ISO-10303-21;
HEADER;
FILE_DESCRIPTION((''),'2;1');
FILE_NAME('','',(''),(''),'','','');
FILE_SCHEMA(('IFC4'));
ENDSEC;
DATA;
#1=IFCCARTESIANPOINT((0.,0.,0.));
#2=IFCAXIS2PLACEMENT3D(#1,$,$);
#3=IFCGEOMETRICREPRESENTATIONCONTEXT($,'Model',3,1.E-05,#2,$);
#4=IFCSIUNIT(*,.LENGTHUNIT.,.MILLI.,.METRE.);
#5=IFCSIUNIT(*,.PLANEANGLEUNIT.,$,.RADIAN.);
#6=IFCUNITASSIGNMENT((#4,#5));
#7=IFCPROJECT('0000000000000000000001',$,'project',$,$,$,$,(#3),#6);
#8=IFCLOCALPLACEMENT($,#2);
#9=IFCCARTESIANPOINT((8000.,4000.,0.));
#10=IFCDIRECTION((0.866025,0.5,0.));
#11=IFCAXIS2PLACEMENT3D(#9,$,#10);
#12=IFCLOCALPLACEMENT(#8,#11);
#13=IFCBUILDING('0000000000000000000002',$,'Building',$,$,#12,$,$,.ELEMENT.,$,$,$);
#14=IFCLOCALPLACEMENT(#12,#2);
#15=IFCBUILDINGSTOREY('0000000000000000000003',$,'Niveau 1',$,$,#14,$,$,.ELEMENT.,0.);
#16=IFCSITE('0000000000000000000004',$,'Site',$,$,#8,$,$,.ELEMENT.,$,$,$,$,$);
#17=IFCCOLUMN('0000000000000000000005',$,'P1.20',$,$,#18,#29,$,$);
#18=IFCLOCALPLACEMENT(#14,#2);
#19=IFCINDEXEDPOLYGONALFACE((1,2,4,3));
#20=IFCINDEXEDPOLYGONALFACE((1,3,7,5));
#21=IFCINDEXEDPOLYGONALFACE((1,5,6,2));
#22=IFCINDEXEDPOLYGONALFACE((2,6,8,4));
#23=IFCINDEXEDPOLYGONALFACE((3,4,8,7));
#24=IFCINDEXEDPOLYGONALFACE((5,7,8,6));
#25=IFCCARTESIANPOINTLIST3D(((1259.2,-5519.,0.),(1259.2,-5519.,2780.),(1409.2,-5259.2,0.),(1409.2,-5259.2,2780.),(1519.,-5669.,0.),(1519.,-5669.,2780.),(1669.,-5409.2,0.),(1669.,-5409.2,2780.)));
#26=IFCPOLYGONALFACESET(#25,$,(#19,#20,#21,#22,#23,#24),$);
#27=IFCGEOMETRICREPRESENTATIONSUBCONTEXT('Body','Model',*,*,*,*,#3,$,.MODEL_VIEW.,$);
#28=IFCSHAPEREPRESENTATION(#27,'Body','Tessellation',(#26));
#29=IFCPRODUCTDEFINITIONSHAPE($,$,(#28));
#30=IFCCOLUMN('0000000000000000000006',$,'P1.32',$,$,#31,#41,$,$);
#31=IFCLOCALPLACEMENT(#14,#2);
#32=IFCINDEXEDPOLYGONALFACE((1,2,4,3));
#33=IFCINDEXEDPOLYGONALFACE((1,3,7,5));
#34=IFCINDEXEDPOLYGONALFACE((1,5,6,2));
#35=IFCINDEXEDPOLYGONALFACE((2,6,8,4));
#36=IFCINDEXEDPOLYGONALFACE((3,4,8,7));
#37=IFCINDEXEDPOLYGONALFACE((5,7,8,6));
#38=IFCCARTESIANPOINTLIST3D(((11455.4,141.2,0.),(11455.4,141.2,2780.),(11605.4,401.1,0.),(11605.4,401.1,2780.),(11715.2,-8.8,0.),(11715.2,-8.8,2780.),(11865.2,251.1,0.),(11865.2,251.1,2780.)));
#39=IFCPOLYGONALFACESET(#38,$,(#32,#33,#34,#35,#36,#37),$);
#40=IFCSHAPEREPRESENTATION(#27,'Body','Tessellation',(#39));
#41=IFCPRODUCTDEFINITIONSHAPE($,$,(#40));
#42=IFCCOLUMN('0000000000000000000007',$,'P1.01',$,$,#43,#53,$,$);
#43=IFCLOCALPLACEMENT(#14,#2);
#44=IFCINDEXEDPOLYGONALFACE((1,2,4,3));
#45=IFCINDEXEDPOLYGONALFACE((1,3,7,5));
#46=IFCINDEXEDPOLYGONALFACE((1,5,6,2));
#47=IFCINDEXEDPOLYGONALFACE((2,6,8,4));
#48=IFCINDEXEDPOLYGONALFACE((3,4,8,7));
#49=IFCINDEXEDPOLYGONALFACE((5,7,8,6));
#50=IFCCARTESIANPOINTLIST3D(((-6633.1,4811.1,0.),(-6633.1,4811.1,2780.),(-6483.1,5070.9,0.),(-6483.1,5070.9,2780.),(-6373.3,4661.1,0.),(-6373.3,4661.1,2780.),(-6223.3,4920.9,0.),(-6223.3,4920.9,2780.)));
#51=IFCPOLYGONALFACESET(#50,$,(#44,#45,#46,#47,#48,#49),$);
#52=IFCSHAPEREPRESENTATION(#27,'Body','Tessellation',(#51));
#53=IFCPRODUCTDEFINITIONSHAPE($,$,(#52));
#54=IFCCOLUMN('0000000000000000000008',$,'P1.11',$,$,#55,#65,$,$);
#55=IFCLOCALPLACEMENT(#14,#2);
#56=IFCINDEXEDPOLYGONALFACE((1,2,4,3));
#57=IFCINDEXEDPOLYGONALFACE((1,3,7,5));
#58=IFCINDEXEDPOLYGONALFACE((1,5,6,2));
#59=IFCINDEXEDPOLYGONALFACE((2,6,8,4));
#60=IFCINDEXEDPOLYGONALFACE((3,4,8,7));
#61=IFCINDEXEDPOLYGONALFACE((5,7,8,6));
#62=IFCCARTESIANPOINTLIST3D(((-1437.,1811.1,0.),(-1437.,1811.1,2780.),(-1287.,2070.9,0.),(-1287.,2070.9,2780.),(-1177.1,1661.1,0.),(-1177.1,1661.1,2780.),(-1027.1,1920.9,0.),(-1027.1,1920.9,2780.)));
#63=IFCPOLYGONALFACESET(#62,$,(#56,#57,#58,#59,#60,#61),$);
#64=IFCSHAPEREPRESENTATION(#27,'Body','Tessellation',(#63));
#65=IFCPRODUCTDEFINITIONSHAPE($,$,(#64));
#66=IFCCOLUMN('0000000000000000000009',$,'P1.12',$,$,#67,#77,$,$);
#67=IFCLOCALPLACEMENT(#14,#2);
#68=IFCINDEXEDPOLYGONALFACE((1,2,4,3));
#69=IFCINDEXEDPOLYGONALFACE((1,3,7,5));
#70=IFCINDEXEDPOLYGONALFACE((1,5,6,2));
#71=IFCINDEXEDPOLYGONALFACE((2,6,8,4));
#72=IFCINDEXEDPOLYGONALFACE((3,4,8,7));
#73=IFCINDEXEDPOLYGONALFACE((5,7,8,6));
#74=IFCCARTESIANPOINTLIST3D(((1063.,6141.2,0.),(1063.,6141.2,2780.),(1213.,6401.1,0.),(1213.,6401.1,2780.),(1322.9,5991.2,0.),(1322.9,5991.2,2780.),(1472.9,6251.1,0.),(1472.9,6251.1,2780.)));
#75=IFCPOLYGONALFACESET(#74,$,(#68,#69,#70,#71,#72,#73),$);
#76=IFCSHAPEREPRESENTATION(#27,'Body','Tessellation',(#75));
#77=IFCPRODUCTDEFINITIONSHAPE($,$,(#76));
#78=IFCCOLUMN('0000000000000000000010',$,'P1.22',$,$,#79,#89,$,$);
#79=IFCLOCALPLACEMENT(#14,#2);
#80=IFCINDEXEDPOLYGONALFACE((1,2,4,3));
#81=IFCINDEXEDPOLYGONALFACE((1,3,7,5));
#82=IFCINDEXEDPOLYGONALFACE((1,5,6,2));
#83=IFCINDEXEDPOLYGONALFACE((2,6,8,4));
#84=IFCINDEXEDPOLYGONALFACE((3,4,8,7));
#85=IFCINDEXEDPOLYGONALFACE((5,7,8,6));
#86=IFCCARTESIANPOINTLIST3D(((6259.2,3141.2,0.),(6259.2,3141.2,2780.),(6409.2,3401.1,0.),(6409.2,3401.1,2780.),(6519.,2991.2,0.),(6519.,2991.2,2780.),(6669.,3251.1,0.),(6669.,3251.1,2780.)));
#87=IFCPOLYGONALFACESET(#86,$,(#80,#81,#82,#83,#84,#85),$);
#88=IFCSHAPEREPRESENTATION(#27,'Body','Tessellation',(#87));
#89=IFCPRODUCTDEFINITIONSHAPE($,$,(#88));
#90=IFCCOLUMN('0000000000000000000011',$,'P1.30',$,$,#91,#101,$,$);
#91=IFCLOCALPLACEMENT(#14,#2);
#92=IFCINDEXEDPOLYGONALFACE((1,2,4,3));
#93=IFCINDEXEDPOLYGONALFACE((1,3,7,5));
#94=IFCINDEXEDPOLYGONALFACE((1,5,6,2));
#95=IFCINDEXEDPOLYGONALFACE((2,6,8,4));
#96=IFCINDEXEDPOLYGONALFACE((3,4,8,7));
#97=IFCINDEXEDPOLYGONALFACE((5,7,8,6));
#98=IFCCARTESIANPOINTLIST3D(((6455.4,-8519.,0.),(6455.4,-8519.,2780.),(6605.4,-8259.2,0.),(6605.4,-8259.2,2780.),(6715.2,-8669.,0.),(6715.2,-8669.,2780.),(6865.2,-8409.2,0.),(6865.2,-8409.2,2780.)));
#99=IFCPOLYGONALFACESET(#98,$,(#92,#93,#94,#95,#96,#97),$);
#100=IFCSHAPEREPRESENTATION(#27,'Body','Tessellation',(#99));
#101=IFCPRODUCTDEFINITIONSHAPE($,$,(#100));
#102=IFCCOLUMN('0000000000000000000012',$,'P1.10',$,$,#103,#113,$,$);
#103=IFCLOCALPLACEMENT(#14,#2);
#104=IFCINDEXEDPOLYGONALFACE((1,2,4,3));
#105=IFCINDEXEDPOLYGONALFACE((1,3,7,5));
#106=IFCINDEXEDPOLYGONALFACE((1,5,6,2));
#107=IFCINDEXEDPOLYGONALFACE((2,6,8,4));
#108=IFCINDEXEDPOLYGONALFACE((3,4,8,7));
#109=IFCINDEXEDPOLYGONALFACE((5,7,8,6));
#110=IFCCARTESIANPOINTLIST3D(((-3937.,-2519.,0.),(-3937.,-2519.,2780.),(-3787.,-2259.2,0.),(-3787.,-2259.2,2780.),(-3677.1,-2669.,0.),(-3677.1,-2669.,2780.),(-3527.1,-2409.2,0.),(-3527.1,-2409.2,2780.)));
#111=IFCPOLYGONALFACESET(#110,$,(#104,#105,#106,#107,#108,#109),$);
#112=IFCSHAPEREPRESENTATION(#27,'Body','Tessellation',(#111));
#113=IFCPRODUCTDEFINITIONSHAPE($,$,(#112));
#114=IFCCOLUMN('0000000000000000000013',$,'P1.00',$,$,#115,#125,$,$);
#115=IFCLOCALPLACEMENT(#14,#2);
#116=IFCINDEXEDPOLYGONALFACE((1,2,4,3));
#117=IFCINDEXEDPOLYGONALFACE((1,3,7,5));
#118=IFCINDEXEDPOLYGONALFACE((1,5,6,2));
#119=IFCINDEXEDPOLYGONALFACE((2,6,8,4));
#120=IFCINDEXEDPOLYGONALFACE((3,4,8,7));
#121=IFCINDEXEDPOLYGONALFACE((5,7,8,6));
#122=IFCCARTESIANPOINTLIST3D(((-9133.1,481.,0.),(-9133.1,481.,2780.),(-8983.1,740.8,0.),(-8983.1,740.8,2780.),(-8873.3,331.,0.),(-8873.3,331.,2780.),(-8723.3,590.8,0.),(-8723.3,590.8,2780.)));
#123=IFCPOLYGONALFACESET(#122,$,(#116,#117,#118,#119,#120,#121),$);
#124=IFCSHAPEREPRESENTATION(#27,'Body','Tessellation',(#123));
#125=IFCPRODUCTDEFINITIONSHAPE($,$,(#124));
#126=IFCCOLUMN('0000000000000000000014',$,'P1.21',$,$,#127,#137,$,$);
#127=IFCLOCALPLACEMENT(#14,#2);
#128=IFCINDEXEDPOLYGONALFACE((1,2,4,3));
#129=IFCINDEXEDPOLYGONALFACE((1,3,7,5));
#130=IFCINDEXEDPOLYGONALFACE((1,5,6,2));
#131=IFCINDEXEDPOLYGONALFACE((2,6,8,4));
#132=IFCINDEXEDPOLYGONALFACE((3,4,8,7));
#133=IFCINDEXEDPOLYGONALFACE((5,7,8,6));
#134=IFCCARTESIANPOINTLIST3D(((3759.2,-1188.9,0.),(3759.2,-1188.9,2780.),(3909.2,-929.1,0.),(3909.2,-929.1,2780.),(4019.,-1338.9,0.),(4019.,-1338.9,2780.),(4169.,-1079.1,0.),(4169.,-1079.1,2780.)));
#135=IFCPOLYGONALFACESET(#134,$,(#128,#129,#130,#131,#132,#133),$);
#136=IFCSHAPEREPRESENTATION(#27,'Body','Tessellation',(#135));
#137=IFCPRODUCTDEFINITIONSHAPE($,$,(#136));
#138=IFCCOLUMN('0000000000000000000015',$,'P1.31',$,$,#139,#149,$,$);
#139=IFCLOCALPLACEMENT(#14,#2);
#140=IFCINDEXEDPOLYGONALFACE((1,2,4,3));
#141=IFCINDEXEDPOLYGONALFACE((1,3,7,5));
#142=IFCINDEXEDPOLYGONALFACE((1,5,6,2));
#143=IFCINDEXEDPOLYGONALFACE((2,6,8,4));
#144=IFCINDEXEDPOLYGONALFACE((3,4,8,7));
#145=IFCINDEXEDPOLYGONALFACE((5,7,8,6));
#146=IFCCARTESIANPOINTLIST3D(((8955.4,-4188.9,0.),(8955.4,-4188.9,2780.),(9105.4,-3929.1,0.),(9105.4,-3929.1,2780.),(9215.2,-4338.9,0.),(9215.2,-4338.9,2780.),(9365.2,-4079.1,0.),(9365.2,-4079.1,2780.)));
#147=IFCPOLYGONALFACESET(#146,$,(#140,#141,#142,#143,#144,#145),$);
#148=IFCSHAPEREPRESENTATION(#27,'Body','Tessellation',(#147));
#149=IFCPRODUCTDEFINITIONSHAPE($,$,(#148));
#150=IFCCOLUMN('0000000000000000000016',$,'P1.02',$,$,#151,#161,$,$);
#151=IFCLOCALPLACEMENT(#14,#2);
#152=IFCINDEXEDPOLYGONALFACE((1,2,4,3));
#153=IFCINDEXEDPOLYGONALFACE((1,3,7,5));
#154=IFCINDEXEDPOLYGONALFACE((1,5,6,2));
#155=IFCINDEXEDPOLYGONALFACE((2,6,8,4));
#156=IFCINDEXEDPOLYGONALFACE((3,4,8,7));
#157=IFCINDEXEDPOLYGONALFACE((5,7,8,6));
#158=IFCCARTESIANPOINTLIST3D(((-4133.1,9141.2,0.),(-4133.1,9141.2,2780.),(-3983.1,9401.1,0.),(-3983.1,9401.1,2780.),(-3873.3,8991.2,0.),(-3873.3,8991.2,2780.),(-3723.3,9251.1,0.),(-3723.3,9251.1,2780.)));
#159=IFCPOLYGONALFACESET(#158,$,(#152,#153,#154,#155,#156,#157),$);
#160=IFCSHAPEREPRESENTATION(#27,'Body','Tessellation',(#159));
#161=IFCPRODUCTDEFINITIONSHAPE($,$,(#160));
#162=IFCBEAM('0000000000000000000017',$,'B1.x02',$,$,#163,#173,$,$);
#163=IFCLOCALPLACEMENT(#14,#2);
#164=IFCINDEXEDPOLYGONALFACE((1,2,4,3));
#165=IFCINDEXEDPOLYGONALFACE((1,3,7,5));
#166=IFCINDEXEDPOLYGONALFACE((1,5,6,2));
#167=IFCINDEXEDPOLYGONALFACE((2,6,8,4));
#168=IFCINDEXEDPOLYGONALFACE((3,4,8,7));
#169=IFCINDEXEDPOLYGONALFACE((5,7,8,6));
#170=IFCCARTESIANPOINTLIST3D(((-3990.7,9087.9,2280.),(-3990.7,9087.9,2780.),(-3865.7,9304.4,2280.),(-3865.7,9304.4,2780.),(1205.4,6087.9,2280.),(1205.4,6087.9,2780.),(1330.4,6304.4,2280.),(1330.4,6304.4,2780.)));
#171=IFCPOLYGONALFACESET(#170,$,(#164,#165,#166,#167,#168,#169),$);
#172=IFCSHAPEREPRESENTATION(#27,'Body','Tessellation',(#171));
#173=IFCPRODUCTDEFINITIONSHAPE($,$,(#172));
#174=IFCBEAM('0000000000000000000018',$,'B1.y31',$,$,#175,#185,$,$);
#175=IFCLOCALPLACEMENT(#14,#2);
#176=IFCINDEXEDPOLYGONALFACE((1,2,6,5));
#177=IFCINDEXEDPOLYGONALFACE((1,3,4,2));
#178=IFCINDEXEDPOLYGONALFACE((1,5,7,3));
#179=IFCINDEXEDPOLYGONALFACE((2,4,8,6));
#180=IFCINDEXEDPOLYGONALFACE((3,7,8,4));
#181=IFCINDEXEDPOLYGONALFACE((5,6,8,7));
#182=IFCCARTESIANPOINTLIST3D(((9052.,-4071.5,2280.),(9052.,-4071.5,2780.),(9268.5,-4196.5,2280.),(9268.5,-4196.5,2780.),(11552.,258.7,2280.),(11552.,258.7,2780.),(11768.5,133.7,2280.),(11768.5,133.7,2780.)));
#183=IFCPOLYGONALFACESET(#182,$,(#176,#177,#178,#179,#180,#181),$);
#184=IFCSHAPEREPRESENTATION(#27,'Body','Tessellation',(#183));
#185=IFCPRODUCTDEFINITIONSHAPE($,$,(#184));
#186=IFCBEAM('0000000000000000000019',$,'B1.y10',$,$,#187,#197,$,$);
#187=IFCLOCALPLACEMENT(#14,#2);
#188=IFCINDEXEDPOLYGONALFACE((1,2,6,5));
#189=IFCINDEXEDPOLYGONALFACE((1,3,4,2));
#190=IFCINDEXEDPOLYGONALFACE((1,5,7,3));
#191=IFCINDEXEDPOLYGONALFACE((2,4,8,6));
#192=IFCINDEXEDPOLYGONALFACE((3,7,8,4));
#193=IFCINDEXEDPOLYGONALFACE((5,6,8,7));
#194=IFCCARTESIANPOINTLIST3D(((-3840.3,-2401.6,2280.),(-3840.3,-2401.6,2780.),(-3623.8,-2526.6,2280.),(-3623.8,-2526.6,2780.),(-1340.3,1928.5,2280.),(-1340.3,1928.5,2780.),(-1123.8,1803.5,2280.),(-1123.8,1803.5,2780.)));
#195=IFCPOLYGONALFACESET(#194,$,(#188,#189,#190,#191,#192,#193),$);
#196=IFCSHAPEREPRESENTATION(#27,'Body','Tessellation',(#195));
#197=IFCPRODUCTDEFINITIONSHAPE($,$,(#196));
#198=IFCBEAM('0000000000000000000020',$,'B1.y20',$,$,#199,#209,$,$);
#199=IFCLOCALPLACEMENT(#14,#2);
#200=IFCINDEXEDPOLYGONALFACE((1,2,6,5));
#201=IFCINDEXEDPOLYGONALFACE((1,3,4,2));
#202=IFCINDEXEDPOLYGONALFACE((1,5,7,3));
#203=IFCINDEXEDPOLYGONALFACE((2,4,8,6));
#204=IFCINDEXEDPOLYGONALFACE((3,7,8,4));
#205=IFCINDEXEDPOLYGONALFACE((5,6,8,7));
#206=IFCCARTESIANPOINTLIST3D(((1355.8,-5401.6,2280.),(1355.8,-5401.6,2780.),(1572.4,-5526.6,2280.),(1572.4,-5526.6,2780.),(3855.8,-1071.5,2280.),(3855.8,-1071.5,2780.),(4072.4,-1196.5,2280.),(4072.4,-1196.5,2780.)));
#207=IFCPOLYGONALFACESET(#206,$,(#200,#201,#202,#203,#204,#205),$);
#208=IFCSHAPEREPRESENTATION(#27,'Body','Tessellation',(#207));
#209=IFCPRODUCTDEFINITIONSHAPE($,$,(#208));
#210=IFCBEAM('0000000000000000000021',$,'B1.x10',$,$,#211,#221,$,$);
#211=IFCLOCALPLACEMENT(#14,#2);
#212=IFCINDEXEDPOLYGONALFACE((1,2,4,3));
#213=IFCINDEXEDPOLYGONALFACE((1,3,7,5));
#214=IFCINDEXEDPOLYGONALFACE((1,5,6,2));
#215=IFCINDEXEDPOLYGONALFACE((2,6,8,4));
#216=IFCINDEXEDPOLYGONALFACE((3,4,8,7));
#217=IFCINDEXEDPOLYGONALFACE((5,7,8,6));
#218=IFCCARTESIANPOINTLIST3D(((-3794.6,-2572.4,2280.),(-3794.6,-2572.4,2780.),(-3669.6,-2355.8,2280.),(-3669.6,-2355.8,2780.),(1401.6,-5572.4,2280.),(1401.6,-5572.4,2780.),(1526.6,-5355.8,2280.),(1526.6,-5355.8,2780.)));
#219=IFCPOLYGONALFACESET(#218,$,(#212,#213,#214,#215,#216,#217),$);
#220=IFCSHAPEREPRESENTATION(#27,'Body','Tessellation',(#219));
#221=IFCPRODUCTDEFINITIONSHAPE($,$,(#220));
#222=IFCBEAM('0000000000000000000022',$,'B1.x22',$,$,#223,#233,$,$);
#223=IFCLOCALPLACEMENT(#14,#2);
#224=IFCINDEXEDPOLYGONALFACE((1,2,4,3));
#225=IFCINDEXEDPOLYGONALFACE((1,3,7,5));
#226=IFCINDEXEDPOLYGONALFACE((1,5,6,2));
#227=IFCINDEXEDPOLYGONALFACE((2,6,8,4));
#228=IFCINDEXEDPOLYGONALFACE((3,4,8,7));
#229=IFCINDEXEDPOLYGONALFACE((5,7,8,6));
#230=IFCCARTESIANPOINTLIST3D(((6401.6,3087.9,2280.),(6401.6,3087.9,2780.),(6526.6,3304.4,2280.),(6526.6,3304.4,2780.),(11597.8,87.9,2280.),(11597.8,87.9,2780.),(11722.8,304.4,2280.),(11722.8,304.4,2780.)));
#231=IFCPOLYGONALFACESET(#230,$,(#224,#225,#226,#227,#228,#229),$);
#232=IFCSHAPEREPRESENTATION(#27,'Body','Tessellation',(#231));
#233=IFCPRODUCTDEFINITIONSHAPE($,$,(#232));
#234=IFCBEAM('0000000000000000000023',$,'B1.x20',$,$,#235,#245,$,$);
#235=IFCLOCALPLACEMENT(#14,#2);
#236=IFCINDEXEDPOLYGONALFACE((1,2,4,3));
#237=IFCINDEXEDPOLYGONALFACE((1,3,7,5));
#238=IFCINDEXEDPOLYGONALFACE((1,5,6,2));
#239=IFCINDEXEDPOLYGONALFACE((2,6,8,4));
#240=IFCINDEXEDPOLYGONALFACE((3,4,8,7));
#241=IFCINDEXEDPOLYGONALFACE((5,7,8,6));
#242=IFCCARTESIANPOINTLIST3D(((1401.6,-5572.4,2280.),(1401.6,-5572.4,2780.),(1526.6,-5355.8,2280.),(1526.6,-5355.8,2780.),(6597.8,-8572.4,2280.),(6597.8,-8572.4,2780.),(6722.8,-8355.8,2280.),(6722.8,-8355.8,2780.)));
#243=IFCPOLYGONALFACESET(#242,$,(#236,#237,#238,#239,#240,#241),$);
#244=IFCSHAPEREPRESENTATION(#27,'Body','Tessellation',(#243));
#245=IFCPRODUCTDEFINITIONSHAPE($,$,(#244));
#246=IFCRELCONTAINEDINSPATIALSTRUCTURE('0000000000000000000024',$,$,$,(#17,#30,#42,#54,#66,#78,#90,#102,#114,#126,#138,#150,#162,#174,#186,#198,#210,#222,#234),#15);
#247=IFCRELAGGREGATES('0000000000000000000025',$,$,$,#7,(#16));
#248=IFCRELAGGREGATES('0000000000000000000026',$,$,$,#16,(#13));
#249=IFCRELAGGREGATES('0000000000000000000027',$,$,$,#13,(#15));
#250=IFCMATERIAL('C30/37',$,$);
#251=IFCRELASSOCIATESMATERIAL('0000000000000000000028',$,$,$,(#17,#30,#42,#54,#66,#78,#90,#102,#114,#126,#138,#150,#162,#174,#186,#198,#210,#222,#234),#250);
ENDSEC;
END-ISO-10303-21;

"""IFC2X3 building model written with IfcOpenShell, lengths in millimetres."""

from ifc_helpers import new_model, si_unit, frame, origin, origin_2d, place, context, subcontext, project, spatial, rectangle, extrude, material, element, save


model = new_model("IFC2X3")

# Units and contexts
model_context = context("Model", 3, precision=1e-05, world=origin())
body_context = subcontext(model_context, "Body", "Model", "MODEL_VIEW")
ifc_project = project(units=[si_unit("LENGTHUNIT", "METRE", prefix="MILLI"), si_unit("PLANEANGLEUNIT", "RADIAN")], contexts=[model_context])

# Site, building, storey
site_placement = place(None, origin())
site = spatial("IfcSite", under=ifc_project, at=site_placement, Name="Site", CompositionType="ELEMENT")
building_placement = place(site_placement, frame((8000.0, 4000.0, 0.0), x_axis=(0.866025, 0.5, 0.0)))
building = spatial("IfcBuilding", under=site, at=building_placement, Name="Building", CompositionType="ELEMENT")
storey_placement = place(building_placement, origin())
storey = spatial("IfcBuildingStorey", under=building, at=storey_placement, Name="Niveau 1", CompositionType="ELEMENT", Elevation=0.0)

# Columns
ifc_material = material(Name="C30/37")
for number, where, z_axis, x_axis, name in (
    (1, (1464.1, -5464.1, 0.0), (0.0, 0.0, 1.0), (0.866025, -0.5, 0.0), "P1.20"),
    (2, (11660.3, 196.2, 0.0), (0.0, 0.0, 1.0), (0.866025, -0.5, 0.0), "P1.32"),
    (3, (-6428.2, 4866.0, 0.0), (0.0, 0.0, 1.0), (0.866025, -0.5, 0.0), "P1.01"),
    (4, (-1232.1, 1866.0, 0.0), (0.0, 0.0, 1.0), (0.866025, -0.5, 0.0), "P1.11"),
    (5, (1267.9, 6196.2, 0.0), (0.0, 0.0, 1.0), (0.866025, -0.5, 0.0), "P1.12"),
    (6, (6464.1, 3196.2, 0.0), (0.0, 0.0, 1.0), (0.866025, -0.5, 0.0), "P1.22"),
    (7, (6660.3, -8464.1, 0.0), (0.0, 0.0, 1.0), (0.866025, -0.5, 0.0), "P1.30"),
    (8, (-3732.1, -2464.1, 0.0), (0.0, 0.0, 1.0), (0.866025, -0.5, 0.0), "P1.10"),
    (9, (-8928.2, 535.9, 0.0), (0.0, 0.0, 1.0), (0.866025, -0.5, 0.0), "P1.00"),
    (10, (3964.1, -1134.0, 0.0), (0.0, 0.0, 1.0), (0.866025, -0.5, 0.0), "P1.21"),
    (11, (9160.3, -4134.0, 0.0), (0.0, 0.0, 1.0), (0.866025, -0.5, 0.0), "P1.31"),
    (12, (-3928.2, 9196.2, 0.0), (0.0, 0.0, 1.0), (0.866025, -0.5, 0.0), "P1.02"),
):
    element("IfcColumn", number, at=place(storey_placement, frame(where, z_axis=z_axis, x_axis=x_axis)), inside=storey, material=ifc_material, Name=name, context=body_context, shape_type="SweptSolid", body=[
        extrude(rectangle(XDim=300.0, YDim=300.0, at=origin_2d()), origin(), (0.0, 0.0, 1.0), 2780.0),
    ])

# Beams
beam_1_placement = place(storey_placement, frame((-3928.2, 9196.2, 2530.0), z_axis=(0.866025, -0.5, 0.0), x_axis=(0.5, 0.866025, 0.0)))
element("IfcBeam", 13, at=beam_1_placement, inside=storey, material=ifc_material, Name="B1.x02", context=body_context, shape_type="SweptSolid", body=[
    extrude(rectangle(XDim=250.0, YDim=500.0, at=origin_2d()), origin(), (0.0, 0.0, 1.0), 6000.0),
])
for number, where, z_axis, x_axis, name in (
    (14, (9160.3, -4134.0, 2530.0), (0.5, 0.866025, 0.0), (-0.866025, 0.5, 0.0), "B1.y31"),
    (15, (-3732.1, -2464.1, 2530.0), (0.5, 0.866025, 0.0), (-0.866025, 0.5, 0.0), "B1.y10"),
    (16, (1464.1, -5464.1, 2530.0), (0.5, 0.866025, 0.0), (-0.866025, 0.5, 0.0), "B1.y20"),
):
    element("IfcBeam", number, at=place(storey_placement, frame(where, z_axis=z_axis, x_axis=x_axis)), inside=storey, material=ifc_material, Name=name, context=body_context, shape_type="SweptSolid", body=[
        extrude(rectangle(XDim=250.0, YDim=500.0, at=origin_2d()), origin(), (0.0, 0.0, 1.0), 5000.0),
    ])
for number, where, z_axis, x_axis, name in (
    (17, (-3732.1, -2464.1, 2530.0), (0.866025, -0.5, 0.0), (0.5, 0.866025, 0.0), "B1.x10"),
    (18, (6464.1, 3196.2, 2530.0), (0.866025, -0.5, 0.0), (0.5, 0.866025, 0.0), "B1.x22"),
    (19, (1464.1, -5464.1, 2530.0), (0.866025, -0.5, 0.0), (0.5, 0.866025, 0.0), "B1.x20"),
):
    element("IfcBeam", number, at=place(storey_placement, frame(where, z_axis=z_axis, x_axis=x_axis)), inside=storey, material=ifc_material, Name=name, context=body_context, shape_type="SweptSolid", body=[
        extrude(rectangle(XDim=250.0, YDim=500.0, at=origin_2d()), origin(), (0.0, 0.0, 1.0), 6000.0),
    ])

save(model, "model.ifc")
